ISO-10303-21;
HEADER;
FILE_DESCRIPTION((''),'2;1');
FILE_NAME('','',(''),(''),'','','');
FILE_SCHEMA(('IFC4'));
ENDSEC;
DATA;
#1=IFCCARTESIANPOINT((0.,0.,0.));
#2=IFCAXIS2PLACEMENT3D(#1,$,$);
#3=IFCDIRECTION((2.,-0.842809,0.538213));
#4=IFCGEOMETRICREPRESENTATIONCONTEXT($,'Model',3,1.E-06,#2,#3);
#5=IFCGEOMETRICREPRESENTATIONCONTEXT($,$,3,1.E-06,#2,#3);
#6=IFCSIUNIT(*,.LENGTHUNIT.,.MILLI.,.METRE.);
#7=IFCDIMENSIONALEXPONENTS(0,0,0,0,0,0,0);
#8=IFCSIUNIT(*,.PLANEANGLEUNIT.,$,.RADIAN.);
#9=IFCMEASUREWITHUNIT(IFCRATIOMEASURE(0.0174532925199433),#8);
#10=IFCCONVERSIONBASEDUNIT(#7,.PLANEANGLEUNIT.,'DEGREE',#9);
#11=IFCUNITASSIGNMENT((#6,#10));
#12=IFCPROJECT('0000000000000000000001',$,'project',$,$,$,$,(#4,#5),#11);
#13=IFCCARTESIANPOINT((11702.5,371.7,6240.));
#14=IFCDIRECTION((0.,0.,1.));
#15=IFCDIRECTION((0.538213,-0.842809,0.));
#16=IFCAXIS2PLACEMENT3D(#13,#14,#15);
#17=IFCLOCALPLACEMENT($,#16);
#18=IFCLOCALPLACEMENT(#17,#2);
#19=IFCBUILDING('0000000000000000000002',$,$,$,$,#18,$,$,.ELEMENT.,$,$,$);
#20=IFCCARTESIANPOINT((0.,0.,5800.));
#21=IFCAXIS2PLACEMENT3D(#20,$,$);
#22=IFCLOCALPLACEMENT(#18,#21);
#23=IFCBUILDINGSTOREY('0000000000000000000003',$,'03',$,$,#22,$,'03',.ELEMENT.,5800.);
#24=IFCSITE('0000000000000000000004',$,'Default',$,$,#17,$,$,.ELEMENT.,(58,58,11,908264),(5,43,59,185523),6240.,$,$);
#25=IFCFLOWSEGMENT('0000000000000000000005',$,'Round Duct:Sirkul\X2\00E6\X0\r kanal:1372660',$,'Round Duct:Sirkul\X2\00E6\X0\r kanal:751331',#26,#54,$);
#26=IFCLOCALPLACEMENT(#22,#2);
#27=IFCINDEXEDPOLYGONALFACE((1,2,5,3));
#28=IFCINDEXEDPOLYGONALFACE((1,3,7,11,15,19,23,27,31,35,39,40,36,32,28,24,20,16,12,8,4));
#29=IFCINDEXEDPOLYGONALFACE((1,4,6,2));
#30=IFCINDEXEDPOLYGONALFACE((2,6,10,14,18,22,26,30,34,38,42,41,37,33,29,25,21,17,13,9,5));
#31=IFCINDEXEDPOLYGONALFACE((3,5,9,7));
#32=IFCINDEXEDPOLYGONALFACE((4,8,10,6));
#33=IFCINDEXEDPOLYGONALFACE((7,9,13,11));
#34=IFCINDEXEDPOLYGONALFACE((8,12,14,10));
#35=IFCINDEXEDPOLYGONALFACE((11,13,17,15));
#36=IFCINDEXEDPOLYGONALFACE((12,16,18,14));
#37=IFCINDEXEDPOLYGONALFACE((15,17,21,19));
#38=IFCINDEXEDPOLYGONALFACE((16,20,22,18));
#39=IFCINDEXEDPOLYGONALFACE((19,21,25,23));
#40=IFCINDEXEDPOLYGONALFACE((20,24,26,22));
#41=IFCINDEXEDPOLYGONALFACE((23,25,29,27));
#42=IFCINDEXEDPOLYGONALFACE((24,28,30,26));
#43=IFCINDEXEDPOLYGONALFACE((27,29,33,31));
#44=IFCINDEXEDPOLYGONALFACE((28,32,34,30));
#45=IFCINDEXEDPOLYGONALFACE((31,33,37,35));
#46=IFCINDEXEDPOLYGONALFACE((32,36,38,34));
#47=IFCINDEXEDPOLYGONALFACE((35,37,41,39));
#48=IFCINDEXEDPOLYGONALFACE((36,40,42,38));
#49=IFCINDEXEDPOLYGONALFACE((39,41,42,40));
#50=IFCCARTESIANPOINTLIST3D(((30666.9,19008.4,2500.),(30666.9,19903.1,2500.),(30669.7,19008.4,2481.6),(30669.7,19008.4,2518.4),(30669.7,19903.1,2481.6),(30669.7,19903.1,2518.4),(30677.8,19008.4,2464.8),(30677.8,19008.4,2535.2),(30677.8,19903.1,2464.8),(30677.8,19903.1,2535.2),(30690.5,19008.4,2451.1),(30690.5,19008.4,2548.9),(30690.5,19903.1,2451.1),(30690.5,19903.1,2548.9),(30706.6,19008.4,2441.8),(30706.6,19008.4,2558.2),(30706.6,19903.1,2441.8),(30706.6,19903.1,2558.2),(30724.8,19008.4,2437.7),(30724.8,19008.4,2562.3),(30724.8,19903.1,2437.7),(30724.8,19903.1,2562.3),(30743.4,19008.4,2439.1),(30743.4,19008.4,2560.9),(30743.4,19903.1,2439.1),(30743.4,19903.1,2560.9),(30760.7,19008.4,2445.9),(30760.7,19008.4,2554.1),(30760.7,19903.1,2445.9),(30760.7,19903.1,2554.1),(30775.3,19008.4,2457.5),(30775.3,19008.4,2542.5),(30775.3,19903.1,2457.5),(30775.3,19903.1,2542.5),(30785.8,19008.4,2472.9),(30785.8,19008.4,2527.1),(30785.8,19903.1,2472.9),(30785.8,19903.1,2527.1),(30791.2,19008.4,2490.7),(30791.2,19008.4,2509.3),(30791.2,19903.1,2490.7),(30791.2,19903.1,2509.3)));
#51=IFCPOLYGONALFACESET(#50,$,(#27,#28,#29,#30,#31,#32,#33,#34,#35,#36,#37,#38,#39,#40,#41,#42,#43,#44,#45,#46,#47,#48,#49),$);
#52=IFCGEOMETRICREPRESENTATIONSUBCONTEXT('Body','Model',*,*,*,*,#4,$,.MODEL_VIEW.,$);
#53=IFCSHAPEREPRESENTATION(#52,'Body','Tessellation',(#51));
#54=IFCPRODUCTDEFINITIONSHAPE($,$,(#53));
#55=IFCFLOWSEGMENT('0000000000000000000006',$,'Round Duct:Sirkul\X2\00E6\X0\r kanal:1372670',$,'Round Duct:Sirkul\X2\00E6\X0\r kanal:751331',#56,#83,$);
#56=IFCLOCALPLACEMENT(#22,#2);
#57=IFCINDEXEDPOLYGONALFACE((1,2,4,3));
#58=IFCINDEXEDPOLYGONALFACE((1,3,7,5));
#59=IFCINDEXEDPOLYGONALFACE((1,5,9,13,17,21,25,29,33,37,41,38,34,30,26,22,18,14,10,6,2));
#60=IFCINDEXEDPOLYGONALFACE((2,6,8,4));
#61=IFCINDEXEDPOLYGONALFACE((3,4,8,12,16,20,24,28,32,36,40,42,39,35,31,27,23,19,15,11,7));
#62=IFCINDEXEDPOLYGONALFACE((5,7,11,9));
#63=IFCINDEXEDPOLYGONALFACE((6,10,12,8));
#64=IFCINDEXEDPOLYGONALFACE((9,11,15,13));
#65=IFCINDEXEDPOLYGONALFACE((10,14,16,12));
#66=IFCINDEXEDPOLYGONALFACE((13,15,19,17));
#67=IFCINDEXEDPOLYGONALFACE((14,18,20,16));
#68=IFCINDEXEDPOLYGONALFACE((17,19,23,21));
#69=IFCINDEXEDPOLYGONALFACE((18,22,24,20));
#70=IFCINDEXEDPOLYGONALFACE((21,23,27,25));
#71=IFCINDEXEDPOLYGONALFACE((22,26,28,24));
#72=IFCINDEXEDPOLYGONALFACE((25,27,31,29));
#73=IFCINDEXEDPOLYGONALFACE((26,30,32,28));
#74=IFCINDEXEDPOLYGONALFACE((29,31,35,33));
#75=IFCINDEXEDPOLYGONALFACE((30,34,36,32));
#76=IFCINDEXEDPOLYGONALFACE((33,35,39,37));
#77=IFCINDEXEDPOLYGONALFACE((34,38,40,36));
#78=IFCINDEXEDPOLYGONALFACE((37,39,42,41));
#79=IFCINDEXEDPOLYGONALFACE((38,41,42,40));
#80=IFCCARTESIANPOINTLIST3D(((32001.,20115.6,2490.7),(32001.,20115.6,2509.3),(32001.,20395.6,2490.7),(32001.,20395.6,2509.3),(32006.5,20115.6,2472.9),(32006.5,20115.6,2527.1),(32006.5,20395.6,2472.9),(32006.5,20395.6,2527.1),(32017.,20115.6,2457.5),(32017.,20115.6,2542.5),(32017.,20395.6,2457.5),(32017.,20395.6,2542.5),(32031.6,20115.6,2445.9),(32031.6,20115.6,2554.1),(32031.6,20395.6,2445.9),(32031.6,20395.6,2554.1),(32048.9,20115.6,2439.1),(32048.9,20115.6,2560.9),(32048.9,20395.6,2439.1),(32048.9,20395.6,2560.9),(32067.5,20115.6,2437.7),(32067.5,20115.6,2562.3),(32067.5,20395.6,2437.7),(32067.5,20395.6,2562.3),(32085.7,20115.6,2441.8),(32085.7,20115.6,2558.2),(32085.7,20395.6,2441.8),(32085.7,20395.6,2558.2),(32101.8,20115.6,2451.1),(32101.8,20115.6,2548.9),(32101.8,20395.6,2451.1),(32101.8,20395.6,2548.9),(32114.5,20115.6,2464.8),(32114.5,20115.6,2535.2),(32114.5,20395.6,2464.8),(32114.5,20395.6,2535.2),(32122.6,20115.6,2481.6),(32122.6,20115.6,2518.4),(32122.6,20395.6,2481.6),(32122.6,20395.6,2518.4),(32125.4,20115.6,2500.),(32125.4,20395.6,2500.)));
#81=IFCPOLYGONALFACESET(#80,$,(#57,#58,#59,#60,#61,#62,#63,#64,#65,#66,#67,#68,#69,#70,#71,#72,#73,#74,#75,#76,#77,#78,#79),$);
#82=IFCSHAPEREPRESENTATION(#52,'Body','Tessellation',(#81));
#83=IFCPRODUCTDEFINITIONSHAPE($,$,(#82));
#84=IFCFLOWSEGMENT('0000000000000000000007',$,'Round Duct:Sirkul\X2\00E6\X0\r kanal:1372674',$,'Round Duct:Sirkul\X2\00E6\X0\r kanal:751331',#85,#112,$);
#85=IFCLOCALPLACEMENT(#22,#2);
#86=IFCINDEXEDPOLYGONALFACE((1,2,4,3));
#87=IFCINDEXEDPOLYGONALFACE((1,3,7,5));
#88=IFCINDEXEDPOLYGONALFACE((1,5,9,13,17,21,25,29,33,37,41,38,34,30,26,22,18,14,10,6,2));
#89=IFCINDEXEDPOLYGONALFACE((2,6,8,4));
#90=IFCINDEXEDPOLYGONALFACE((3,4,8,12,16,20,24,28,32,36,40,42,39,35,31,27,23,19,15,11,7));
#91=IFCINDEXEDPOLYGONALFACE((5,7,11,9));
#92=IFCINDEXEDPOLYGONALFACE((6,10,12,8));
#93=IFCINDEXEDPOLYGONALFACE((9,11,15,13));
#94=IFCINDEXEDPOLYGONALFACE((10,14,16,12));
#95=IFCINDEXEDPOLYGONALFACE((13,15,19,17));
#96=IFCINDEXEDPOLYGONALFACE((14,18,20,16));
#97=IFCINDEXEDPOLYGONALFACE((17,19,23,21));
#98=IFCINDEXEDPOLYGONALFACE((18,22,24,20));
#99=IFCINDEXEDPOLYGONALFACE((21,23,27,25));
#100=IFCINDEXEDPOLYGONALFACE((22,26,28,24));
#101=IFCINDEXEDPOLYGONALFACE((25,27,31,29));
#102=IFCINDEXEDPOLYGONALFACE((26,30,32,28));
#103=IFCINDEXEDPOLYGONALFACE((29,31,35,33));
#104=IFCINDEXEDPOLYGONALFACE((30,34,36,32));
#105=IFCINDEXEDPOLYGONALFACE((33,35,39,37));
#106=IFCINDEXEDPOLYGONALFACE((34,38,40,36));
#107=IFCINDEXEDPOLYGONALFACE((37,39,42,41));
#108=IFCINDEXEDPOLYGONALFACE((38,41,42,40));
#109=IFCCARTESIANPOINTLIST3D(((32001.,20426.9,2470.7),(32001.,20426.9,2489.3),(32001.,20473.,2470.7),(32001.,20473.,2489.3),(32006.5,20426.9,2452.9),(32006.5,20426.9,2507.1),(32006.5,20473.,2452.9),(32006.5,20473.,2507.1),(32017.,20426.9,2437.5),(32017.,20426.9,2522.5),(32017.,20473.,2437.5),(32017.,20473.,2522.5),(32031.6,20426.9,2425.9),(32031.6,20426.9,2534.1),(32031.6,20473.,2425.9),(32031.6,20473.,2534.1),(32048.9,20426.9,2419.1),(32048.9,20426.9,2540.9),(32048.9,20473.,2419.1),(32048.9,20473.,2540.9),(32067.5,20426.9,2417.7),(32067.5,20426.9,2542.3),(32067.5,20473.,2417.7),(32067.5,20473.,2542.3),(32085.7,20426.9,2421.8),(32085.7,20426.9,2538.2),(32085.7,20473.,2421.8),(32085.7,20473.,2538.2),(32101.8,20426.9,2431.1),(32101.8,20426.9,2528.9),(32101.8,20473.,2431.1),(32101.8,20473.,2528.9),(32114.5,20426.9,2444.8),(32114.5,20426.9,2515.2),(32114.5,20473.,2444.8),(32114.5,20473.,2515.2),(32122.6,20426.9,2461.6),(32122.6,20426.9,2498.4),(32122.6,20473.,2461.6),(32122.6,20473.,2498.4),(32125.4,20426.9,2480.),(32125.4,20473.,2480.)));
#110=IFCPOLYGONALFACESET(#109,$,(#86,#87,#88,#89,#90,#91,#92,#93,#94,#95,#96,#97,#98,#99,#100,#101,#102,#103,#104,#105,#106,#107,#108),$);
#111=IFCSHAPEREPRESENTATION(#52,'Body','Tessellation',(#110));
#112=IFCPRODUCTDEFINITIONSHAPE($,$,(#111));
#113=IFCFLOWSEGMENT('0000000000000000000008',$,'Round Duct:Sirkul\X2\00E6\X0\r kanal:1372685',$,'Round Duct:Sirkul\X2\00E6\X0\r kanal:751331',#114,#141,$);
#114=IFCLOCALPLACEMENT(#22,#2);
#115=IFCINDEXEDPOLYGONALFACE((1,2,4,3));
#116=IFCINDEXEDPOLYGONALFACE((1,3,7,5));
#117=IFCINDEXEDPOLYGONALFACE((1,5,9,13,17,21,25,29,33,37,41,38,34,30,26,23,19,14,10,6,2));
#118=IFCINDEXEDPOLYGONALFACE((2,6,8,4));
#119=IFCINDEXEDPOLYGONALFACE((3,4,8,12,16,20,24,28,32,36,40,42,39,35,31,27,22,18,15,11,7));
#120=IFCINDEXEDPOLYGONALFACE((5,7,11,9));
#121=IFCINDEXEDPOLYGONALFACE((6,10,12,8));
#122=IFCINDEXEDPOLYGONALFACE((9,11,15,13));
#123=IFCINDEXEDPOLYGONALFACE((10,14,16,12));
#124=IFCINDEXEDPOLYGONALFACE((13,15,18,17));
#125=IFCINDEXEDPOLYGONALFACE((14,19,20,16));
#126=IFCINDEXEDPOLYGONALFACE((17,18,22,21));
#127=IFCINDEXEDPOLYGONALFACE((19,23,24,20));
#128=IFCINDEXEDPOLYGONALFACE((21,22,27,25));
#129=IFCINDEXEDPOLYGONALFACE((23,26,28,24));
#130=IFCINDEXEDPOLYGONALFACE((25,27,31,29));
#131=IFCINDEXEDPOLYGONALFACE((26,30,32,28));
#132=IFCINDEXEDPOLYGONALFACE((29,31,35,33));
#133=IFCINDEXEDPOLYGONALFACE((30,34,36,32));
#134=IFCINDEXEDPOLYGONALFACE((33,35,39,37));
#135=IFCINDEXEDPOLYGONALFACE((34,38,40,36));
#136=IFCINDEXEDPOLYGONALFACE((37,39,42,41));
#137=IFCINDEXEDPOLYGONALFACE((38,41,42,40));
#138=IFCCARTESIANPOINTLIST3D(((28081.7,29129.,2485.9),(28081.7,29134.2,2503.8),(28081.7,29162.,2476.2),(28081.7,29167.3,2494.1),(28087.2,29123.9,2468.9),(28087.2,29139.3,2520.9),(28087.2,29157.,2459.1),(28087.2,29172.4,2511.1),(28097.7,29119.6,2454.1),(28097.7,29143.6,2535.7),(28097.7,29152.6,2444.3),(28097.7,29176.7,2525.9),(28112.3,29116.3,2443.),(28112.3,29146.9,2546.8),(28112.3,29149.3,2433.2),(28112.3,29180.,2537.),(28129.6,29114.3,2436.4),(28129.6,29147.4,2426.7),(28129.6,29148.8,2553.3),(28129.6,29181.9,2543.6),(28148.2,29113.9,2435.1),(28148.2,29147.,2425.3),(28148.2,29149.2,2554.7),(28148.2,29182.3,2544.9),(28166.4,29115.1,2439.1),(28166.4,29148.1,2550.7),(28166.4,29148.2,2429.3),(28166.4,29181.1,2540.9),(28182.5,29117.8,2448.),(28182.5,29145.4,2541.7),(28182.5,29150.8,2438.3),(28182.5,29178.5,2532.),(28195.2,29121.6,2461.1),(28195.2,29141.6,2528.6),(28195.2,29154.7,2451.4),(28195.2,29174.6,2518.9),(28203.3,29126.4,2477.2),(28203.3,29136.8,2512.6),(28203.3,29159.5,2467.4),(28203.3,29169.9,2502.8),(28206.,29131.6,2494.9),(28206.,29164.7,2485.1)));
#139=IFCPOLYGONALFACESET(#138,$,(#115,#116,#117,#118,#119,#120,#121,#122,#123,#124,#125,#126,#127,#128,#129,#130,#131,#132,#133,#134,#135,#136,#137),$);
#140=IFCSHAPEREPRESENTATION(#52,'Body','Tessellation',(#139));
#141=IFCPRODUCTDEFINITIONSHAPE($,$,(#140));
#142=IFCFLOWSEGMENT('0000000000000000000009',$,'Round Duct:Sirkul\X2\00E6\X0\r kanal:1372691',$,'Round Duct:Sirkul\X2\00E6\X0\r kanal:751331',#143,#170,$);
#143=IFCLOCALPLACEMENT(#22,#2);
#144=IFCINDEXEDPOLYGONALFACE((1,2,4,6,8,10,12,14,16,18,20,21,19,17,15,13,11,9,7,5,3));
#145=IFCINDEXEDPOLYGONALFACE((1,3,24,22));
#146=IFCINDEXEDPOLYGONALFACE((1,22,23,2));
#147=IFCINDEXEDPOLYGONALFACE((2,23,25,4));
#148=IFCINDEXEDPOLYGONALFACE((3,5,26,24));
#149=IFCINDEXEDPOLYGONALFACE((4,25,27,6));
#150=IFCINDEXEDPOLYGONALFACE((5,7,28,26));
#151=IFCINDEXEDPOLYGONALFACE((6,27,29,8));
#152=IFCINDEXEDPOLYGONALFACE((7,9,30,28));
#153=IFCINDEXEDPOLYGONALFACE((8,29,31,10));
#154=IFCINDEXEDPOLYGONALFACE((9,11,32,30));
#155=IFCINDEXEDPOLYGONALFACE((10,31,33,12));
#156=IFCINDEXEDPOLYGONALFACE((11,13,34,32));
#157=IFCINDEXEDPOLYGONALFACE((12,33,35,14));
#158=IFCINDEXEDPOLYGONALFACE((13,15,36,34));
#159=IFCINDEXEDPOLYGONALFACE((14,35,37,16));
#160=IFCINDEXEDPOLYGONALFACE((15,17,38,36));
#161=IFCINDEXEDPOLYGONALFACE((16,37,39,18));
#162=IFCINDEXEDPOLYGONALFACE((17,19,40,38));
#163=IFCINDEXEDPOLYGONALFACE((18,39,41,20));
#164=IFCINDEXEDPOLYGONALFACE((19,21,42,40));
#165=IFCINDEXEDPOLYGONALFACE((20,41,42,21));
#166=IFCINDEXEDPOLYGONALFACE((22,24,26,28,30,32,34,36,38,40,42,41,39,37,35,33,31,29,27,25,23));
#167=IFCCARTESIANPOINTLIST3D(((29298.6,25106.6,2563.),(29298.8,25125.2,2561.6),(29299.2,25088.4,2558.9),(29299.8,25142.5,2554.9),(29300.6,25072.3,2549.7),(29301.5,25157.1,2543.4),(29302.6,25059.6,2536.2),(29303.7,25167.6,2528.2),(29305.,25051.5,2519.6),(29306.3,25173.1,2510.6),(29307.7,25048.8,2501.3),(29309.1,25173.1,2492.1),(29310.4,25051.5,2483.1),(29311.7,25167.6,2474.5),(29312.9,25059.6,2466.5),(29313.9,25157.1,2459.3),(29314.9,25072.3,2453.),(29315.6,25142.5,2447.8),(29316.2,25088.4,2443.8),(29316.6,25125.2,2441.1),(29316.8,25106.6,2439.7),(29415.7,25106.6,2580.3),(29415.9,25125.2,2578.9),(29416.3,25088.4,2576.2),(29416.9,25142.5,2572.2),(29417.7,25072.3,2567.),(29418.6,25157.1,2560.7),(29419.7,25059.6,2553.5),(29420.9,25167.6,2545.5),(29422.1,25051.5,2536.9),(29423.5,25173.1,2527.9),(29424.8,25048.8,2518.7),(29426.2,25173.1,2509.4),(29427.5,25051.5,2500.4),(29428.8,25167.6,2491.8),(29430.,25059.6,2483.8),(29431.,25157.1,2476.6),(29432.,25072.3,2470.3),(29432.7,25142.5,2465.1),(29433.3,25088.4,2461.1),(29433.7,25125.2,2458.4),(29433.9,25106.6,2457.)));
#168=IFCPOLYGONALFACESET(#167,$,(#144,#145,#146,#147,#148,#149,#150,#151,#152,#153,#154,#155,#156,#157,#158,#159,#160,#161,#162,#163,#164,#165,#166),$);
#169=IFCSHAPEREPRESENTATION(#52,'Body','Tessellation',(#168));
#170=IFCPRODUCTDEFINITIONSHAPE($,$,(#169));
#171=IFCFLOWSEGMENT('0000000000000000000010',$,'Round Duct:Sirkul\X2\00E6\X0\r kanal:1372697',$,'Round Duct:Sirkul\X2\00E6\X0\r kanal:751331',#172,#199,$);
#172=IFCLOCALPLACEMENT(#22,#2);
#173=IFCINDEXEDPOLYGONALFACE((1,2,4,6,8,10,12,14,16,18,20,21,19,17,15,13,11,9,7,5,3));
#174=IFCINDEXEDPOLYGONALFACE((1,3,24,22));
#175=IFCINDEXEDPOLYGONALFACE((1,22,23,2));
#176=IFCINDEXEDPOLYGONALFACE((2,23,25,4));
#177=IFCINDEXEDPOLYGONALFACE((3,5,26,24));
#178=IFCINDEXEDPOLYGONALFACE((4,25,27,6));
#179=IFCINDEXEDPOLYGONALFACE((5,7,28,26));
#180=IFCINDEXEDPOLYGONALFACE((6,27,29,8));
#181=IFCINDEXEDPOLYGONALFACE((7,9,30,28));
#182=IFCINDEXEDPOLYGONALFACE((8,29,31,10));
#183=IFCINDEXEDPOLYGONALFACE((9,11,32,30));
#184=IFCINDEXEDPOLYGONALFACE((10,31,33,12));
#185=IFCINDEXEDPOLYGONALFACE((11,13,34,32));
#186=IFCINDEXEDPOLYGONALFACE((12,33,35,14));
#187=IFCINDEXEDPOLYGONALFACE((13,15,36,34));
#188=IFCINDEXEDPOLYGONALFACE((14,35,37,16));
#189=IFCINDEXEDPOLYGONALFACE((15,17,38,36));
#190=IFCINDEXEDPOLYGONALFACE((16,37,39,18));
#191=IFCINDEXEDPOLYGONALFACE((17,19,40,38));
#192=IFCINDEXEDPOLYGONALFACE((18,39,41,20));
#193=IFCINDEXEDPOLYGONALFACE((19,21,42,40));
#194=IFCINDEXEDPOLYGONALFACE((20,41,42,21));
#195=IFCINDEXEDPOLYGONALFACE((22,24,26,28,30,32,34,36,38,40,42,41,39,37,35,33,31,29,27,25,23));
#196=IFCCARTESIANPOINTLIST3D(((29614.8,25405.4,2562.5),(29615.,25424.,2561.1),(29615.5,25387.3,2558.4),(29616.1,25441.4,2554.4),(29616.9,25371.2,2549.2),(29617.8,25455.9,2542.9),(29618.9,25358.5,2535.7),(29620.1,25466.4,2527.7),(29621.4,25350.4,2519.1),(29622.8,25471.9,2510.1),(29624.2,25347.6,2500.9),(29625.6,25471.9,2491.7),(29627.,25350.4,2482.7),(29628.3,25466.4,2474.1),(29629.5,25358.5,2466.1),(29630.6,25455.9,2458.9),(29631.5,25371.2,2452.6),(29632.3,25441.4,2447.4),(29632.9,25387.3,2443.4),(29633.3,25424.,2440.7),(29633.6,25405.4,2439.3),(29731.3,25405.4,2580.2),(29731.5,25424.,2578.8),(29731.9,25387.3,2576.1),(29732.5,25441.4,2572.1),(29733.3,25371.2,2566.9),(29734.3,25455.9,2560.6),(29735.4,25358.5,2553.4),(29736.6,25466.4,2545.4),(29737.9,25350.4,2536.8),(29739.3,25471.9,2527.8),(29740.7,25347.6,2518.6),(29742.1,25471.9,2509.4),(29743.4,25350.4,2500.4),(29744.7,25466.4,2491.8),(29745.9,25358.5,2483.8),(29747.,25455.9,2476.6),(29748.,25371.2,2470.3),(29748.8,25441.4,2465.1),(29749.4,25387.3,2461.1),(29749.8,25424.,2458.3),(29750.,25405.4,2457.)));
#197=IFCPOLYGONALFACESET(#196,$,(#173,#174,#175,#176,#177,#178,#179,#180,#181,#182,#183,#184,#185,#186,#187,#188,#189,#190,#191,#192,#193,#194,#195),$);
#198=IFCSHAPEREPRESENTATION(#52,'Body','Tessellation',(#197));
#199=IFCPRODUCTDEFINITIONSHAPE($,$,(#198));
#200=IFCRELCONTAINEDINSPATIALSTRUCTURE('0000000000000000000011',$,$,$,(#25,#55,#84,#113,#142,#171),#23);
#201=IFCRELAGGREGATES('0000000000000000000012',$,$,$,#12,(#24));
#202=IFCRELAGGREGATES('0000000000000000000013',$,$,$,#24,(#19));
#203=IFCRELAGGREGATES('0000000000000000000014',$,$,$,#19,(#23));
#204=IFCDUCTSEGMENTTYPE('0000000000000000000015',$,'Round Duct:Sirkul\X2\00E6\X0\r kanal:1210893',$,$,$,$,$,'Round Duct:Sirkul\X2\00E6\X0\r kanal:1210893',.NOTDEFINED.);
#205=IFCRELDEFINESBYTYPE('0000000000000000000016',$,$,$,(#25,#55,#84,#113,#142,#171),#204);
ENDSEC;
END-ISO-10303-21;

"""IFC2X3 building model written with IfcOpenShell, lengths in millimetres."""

from ifc_helpers import new_model, entity, si_unit, converted_unit, direction, frame, frame_2d, origin, origin_2d_with_axis, place, context, subcontext, project, spatial, circle, extrude, type_object, element, save


model = new_model("IFC2X3")

# Units and contexts
model_context = context("Model", 3, precision=1e-06, world=origin(), true_north=direction((2.0, -0.842809, 0.538213)))
context_of_model = context(None, 3, precision=1e-06, world=origin(), true_north=direction((2.0, -0.842809, 0.538213)))
body_context = subcontext(model_context, "Body", "Model", "MODEL_VIEW")
ifc_project = project(units=[si_unit("LENGTHUNIT", "METRE", prefix="MILLI"), converted_unit("PLANEANGLEUNIT", "DEGREE", entity("IfcRatioMeasure", 0.0174532925199433), si_unit("PLANEANGLEUNIT", "RADIAN"), dimensions=[0, 0, 0, 0, 0, 0, 0])], contexts=[model_context, context_of_model])

# Site, building, storey
site_placement = place(None, frame((11702.5, 371.7, 6240.0), z_axis=(0.0, 0.0, 1.0), x_axis=(0.538213, -0.842809, 0.0)))
site = spatial("IfcSite", under=ifc_project, at=site_placement, Name="Default", CompositionType="ELEMENT", RefLatitude=(58, 58, 11, 908264), RefLongitude=(5, 43, 59, 185523), RefElevation=6240.0)
building_placement = place(site_placement, origin())
building = spatial("IfcBuilding", under=site, at=building_placement, CompositionType="ELEMENT")
storey_placement = place(building_placement, frame((0.0, 0.0, 5800.0)))
storey = spatial("IfcBuildingStorey", under=building, at=storey_placement, Name="03", LongName="03", CompositionType="ELEMENT", Elevation=5800.0)

# Flow segments
duct_segment_type_1 = type_object("IfcDuctSegmentType", Name="Round Duct:Sirkulær kanal:1210893", ElementType="Round Duct:Sirkulær kanal:1210893", PredefinedType="NOTDEFINED")
flow_segment_1_placement = place(storey_placement, origin())
element("IfcFlowSegment", 1, at=flow_segment_1_placement, inside=storey, type_object=duct_segment_type_1, Name="Round Duct:Sirkulær kanal:1372660", ObjectType="Round Duct:Sirkulær kanal:751331", context=body_context, shape_type="SweptSolid", body=[
    extrude(circle(Radius=62.5, at=frame_2d((0.0, 0.0), x_axis=(1.0, 0.0))), frame((30729.4, 19008.4, 2500.0), z_axis=(0.0, 1.0, 0.0), x_axis=(-1.0, 0.0, 0.0)), (0.0, 0.0, 1.0), 894.7),
])
flow_segment_2_placement = place(storey_placement, origin())
element("IfcFlowSegment", 2, at=flow_segment_2_placement, inside=storey, type_object=duct_segment_type_1, Name="Round Duct:Sirkulær kanal:1372670", ObjectType="Round Duct:Sirkulær kanal:751331", context=body_context, shape_type="SweptSolid", body=[
    extrude(circle(Radius=62.5, at=origin_2d_with_axis()), frame((32062.9, 20115.6, 2500.0), z_axis=(0.0, 1.0, 0.0), x_axis=(1.0, 0.0, 0.0)), (0.0, 0.0, 1.0), 280.0),
])
flow_segment_3_placement = place(storey_placement, origin())
element("IfcFlowSegment", 3, at=flow_segment_3_placement, inside=storey, type_object=duct_segment_type_1, Name="Round Duct:Sirkulær kanal:1372674", ObjectType="Round Duct:Sirkulær kanal:751331", context=body_context, shape_type="SweptSolid", body=[
    extrude(circle(Radius=62.5, at=origin_2d_with_axis()), frame((32062.9, 20426.9, 2480.0), z_axis=(0.0, 1.0, 0.0), x_axis=(1.0, 0.0, 0.0)), (0.0, 0.0, 1.0), 46.1),
])
flow_segment_4_placement = place(storey_placement, origin())
element("IfcFlowSegment", 4, at=flow_segment_4_placement, inside=storey, type_object=duct_segment_type_1, Name="Round Duct:Sirkulær kanal:1372685", ObjectType="Round Duct:Sirkulær kanal:751331", context=body_context, shape_type="SweptSolid", body=[
    extrude(circle(Radius=62.5, at=frame_2d((0.0, 0.0), x_axis=(1.0, 0.0))), frame((28143.5, 29131.6, 2494.9), z_axis=(0.0, 0.959068, -0.283175), x_axis=(1.0, 0.0, 0.0)), (0.0, 0.0, 1.0), 34.5),
])
flow_segment_5_placement = place(storey_placement, origin())
element("IfcFlowSegment", 5, at=flow_segment_5_placement, inside=storey, type_object=duct_segment_type_1, Name="Round Duct:Sirkulær kanal:1372691", ObjectType="Round Duct:Sirkulær kanal:751331", context=body_context, shape_type="SweptSolid", body=[
    extrude(circle(Radius=62.5, at=frame_2d((0.0, 0.0), x_axis=(1.0, 0.0))), frame((29307.7, 25111.3, 2501.3), z_axis=(0.98925, 0.0, 0.146233), x_axis=(0.0, -1.0, 0.0)), (0.0, 0.0, 1.0), 118.4),
])
flow_segment_6_placement = place(storey_placement, origin())
element("IfcFlowSegment", 6, at=flow_segment_6_placement, inside=storey, type_object=duct_segment_type_1, Name="Round Duct:Sirkulær kanal:1372697", ObjectType="Round Duct:Sirkulær kanal:751331", context=body_context, shape_type="SweptSolid", body=[
    extrude(circle(Radius=62.5, at=frame_2d((0.0, 0.0), x_axis=(1.0, 0.0))), frame((29624.2, 25410.1, 2500.9), z_axis=(0.988662, 0.0, 0.150158), x_axis=(0.0, -1.0, 0.0)), (0.0, 0.0, 1.0), 117.8),
])

save(model, "model.ifc")
